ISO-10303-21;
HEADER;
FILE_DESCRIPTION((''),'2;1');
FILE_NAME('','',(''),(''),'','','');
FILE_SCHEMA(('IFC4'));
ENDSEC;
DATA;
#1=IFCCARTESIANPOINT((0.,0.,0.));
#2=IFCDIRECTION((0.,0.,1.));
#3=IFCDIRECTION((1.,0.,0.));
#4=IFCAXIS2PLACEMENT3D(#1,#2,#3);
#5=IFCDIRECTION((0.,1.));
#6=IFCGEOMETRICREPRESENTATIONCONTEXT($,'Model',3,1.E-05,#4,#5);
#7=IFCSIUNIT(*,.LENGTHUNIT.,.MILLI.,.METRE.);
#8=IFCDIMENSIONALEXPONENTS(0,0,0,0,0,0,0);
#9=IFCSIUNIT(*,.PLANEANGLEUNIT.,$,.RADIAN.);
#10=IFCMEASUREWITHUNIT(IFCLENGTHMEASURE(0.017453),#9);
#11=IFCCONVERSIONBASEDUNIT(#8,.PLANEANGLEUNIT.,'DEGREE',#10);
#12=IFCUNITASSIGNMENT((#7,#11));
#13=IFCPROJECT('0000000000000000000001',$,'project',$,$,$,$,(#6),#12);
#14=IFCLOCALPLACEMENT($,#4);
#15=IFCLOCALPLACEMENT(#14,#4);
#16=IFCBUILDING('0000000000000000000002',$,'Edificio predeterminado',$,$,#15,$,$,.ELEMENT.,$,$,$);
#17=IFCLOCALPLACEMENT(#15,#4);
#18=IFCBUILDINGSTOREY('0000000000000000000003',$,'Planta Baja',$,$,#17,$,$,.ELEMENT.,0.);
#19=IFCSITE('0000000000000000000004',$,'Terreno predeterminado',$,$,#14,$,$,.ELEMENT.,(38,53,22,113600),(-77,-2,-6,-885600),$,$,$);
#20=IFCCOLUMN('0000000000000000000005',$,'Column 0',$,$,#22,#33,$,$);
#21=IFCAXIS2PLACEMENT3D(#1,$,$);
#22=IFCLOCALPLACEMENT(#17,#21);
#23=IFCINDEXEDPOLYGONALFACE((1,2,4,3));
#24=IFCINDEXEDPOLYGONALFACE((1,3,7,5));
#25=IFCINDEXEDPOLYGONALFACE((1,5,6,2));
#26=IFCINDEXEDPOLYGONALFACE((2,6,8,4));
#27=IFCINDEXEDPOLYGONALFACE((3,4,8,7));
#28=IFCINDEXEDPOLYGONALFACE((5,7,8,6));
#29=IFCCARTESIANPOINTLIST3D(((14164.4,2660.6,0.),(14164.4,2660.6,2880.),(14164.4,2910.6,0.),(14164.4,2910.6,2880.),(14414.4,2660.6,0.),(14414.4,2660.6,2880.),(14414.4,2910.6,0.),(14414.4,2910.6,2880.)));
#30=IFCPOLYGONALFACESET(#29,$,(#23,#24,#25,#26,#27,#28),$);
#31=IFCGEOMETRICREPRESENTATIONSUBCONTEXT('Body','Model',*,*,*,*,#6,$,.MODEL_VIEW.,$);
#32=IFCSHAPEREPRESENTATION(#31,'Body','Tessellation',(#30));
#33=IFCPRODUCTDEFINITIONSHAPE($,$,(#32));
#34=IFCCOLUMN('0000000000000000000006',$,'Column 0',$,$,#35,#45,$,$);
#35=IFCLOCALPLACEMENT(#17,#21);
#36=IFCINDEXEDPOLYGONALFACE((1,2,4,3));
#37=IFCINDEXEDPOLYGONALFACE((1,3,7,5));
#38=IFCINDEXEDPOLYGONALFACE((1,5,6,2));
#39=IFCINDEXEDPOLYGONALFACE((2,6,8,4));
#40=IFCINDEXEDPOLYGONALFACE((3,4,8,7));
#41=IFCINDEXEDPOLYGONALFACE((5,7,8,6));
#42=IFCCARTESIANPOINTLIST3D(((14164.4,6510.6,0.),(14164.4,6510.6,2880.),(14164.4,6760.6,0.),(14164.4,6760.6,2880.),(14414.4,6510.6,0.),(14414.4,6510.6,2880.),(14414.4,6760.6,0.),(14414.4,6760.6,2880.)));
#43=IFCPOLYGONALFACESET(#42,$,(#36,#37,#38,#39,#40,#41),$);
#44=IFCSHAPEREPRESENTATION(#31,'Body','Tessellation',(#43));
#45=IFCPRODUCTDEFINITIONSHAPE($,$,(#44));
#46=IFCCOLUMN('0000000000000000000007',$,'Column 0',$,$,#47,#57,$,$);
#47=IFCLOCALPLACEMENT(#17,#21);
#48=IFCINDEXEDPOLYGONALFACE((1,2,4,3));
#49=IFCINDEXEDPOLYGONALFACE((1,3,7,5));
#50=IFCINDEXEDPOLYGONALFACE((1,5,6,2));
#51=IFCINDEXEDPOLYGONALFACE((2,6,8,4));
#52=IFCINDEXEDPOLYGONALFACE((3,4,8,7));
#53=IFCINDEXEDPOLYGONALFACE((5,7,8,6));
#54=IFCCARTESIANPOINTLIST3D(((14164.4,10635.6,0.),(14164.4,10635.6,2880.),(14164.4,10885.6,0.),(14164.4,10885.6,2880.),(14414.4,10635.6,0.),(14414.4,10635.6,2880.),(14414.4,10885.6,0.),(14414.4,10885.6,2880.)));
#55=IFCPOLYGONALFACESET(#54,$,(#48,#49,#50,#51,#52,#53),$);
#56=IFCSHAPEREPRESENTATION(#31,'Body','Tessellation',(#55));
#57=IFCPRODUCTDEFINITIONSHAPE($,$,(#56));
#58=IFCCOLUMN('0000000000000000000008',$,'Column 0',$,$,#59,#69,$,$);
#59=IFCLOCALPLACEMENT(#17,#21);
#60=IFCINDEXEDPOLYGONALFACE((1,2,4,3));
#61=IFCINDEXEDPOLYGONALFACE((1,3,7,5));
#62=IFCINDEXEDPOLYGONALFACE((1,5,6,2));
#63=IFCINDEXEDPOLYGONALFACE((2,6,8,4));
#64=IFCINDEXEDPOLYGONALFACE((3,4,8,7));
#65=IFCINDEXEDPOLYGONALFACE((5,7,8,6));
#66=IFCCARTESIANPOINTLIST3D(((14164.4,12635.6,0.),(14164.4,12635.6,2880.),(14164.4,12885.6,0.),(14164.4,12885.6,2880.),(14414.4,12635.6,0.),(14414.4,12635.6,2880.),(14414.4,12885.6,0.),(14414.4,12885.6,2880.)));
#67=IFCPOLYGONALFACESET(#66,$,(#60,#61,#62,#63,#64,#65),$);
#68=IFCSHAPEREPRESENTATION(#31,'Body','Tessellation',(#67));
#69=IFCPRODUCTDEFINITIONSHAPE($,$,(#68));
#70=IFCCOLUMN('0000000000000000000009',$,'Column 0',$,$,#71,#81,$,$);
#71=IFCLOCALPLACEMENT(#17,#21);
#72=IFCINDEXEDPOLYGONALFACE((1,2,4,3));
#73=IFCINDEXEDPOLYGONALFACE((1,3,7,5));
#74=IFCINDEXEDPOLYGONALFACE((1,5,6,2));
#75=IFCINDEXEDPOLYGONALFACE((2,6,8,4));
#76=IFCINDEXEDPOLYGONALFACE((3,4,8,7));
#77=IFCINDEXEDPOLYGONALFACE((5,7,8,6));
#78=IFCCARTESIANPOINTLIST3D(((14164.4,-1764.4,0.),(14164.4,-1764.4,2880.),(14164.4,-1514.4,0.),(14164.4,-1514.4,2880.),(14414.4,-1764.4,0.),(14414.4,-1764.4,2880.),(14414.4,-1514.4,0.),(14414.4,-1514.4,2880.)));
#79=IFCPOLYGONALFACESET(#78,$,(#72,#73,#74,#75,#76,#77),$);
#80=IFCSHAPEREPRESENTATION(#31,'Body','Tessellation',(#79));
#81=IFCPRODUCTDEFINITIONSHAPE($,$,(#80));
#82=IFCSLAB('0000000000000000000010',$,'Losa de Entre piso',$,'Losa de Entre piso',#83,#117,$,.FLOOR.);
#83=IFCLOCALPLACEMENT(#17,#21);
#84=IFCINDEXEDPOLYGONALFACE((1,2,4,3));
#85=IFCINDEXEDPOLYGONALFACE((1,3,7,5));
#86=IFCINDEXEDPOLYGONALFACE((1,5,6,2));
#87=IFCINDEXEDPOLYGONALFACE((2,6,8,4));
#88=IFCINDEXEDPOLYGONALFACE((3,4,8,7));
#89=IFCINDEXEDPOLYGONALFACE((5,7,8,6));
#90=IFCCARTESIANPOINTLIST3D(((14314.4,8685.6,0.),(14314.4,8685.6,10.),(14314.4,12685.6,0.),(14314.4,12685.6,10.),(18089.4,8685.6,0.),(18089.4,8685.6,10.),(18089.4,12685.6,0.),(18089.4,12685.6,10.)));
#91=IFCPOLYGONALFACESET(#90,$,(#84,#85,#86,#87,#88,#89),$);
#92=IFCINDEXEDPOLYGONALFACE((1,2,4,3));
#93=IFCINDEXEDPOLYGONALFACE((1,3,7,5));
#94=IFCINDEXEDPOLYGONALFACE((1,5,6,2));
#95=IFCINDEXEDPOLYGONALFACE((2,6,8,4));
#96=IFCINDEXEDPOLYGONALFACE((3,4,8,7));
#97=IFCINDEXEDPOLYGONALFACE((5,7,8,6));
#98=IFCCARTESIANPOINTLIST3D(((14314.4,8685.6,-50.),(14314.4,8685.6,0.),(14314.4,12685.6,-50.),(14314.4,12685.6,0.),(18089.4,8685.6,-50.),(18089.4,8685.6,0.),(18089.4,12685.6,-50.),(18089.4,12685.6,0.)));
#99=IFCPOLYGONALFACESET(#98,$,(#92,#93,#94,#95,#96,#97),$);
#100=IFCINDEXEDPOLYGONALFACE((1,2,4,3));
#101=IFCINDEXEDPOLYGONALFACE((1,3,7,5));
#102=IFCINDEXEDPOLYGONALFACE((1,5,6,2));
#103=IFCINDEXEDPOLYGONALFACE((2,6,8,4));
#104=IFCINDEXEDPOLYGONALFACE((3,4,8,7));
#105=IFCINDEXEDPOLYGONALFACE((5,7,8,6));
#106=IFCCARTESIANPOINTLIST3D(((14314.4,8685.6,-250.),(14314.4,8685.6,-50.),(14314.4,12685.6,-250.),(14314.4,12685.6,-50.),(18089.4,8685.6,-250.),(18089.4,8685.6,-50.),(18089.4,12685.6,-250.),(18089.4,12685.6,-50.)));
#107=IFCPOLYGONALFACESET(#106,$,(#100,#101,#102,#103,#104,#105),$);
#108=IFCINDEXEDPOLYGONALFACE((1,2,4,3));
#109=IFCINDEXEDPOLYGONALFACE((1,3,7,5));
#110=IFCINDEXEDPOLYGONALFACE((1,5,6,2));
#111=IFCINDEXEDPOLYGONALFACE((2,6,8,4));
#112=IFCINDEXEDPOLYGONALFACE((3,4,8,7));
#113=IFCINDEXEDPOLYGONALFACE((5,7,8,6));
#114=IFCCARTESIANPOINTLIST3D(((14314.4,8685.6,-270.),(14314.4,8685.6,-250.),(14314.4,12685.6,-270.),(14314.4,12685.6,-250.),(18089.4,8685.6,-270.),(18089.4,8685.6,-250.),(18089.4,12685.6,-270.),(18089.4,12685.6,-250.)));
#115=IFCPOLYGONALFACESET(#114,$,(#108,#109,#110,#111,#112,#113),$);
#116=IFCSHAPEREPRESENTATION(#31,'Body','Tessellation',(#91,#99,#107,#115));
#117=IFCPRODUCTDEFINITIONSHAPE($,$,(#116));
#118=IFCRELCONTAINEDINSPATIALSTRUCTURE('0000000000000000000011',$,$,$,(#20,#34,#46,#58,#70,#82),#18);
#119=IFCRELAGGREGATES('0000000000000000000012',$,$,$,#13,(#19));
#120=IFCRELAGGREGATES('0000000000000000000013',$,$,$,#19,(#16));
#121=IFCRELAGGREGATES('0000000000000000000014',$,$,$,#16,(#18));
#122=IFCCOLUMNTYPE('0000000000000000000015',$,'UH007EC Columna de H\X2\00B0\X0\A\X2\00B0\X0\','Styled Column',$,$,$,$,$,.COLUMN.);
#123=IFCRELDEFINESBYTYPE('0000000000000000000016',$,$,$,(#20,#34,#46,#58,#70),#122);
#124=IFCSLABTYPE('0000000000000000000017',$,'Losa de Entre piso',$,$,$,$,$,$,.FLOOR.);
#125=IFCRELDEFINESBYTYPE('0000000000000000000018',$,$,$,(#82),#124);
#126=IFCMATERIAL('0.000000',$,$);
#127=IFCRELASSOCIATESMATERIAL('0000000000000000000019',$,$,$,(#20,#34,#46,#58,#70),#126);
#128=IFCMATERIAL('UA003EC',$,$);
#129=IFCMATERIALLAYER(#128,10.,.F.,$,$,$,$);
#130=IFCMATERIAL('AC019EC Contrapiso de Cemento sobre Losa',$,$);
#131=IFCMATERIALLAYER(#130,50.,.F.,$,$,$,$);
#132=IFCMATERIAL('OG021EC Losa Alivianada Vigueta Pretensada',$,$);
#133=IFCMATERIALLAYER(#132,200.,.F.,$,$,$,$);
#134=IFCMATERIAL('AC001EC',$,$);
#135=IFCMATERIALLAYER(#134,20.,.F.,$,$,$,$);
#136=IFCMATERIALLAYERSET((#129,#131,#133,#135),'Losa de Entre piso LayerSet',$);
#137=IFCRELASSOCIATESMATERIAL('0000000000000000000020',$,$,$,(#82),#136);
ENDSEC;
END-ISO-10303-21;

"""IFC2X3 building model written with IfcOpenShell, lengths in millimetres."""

from ifc_helpers import new_model, entity, si_unit, converted_unit, direction, frame, origin_with_axes, place, context, subcontext, project, spatial, polyline, outline, extrude, material, layer, layer_set, layer_usage, type_object, element, save


model = new_model("IFC2X3")

# Units and contexts
model_context = context("Model", 3, precision=1e-05, world=origin_with_axes(), true_north=direction((0.0, 1.0)))
body_context = subcontext(model_context, "Body", "Model", "MODEL_VIEW")
ifc_project = project(units=[si_unit("LENGTHUNIT", "METRE", prefix="MILLI"), converted_unit("PLANEANGLEUNIT", "DEGREE", entity("IfcLengthMeasure", 0.017453), si_unit("PLANEANGLEUNIT", "RADIAN"), dimensions=[0, 0, 0, 0, 0, 0, 0])], contexts=[model_context])

# Site, building, storey
site_placement = place(None, origin_with_axes())
site = spatial("IfcSite", under=ifc_project, at=site_placement, Name="Terreno predeterminado", CompositionType="ELEMENT", RefLatitude=(38, 53, 22, 113600), RefLongitude=(-77, -2, -6, -885600))
building_placement = place(site_placement, origin_with_axes())
building = spatial("IfcBuilding", under=site, at=building_placement, Name="Edificio predeterminado", CompositionType="ELEMENT")
storey_placement = place(building_placement, origin_with_axes())
storey = spatial("IfcBuildingStorey", under=building, at=storey_placement, Name="Planta Baja", CompositionType="ELEMENT", Elevation=0.0)

# Columns
ifc_material_1 = material(Name="0.000000")
column_type = type_object("IfcColumnType", Name="UH007EC Columna de H°A°", Description="Styled Column", PredefinedType="COLUMN")
for number, where, z_axis, x_axis, name in (
    (1, (14289.4, 2785.6, 0.0), (0.0, 0.0, 1.0), (1.0, 0.0, 0.0), "Column 0"),
    (2, (14289.4, 6635.6, 0.0), (0.0, 0.0, 1.0), (1.0, 0.0, 0.0), "Column 0"),
    (3, (14289.4, 10760.6, 0.0), (0.0, 0.0, 1.0), (1.0, 0.0, 0.0), "Column 0"),
    (4, (14289.4, 12760.6, 0.0), (0.0, 0.0, 1.0), (1.0, 0.0, 0.0), "Column 0"),
    (5, (14289.4, -1639.4, 0.0), (0.0, 0.0, 1.0), (1.0, 0.0, 0.0), "Column 0"),
):
    element("IfcColumn", number, at=place(storey_placement, frame(where, z_axis=z_axis, x_axis=x_axis)), inside=storey, type_object=column_type, material=ifc_material_1, Name=name, context=body_context, shape_type="SweptSolid", body=[
        extrude(outline(polyline([(-125.0, -125.0), (125.0, -125.0), (125.0, 125.0), (-125.0, 125.0), (-125.0, -125.0)])), origin_with_axes(), (0.0, 0.0, 1.0), 2880.0),
    ])

# Slab
ifc_material_2 = material(Name="UA003EC")
ifc_layer_1 = layer(ifc_material_2, 10.0, ventilated=False)
ifc_material_3 = material(Name="AC019EC Contrapiso de Cemento sobre Losa")
ifc_layer_2 = layer(ifc_material_3, 50.0, ventilated=False)
ifc_material_4 = material(Name="OG021EC Losa Alivianada Vigueta Pretensada")
ifc_layer_3 = layer(ifc_material_4, 200.0, ventilated=False)
ifc_material_5 = material(Name="AC001EC")
ifc_layer_4 = layer(ifc_material_5, 20.0, ventilated=False)
ifc_layer_set_1 = layer_set([ifc_layer_1, ifc_layer_2, ifc_layer_3, ifc_layer_4], Name="Losa de Entre piso LayerSet")
ifc_layer_usage_1 = layer_usage(ifc_layer_set_1, "AXIS3", "NEGATIVE", 0.0)
slab_type = type_object("IfcSlabType", Name="Losa de Entre piso", PredefinedType="FLOOR")
slab_1_placement = place(storey_placement, origin_with_axes())
element("IfcSlab", 6, at=slab_1_placement, inside=storey, type_object=slab_type, material=ifc_layer_usage_1, Name="Losa de Entre piso", ObjectType="Losa de Entre piso", PredefinedType="FLOOR", context=body_context, shape_type="SweptSolid", body=[
    extrude(outline(polyline([(0.0, 4000.0), (3775.0, 4000.0), (3775.0, 0.0), (0.0, 0.0), (0.0, 4000.0)])), frame((14314.4, 12685.6, 0.0), z_axis=(0.0, 0.0, -1.0), x_axis=(1.0, 0.0, 0.0)), (0.0, 0.0, -1.0), 10.0),
    extrude(outline(polyline([(0.0, 4000.0), (3775.0, 4000.0), (3775.0, 0.0), (0.0, 0.0), (0.0, 4000.0)])), frame((14314.4, 12685.6, -50.0), z_axis=(0.0, 0.0, -1.0), x_axis=(1.0, 0.0, 0.0)), (0.0, 0.0, -1.0), 50.0),
    extrude(outline(polyline([(0.0, 4000.0), (3775.0, 4000.0), (3775.0, 0.0), (0.0, 0.0), (0.0, 4000.0)])), frame((14314.4, 12685.6, -250.0), z_axis=(0.0, 0.0, -1.0), x_axis=(1.0, 0.0, 0.0)), (0.0, 0.0, -1.0), 200.0),
    extrude(outline(polyline([(0.0, 4000.0), (3775.0, 4000.0), (3775.0, 0.0), (0.0, 0.0), (0.0, 4000.0)])), frame((14314.4, 12685.6, -270.0), z_axis=(0.0, 0.0, -1.0), x_axis=(1.0, 0.0, 0.0)), (0.0, 0.0, -1.0), 20.0),
])

save(model, "model.ifc")
